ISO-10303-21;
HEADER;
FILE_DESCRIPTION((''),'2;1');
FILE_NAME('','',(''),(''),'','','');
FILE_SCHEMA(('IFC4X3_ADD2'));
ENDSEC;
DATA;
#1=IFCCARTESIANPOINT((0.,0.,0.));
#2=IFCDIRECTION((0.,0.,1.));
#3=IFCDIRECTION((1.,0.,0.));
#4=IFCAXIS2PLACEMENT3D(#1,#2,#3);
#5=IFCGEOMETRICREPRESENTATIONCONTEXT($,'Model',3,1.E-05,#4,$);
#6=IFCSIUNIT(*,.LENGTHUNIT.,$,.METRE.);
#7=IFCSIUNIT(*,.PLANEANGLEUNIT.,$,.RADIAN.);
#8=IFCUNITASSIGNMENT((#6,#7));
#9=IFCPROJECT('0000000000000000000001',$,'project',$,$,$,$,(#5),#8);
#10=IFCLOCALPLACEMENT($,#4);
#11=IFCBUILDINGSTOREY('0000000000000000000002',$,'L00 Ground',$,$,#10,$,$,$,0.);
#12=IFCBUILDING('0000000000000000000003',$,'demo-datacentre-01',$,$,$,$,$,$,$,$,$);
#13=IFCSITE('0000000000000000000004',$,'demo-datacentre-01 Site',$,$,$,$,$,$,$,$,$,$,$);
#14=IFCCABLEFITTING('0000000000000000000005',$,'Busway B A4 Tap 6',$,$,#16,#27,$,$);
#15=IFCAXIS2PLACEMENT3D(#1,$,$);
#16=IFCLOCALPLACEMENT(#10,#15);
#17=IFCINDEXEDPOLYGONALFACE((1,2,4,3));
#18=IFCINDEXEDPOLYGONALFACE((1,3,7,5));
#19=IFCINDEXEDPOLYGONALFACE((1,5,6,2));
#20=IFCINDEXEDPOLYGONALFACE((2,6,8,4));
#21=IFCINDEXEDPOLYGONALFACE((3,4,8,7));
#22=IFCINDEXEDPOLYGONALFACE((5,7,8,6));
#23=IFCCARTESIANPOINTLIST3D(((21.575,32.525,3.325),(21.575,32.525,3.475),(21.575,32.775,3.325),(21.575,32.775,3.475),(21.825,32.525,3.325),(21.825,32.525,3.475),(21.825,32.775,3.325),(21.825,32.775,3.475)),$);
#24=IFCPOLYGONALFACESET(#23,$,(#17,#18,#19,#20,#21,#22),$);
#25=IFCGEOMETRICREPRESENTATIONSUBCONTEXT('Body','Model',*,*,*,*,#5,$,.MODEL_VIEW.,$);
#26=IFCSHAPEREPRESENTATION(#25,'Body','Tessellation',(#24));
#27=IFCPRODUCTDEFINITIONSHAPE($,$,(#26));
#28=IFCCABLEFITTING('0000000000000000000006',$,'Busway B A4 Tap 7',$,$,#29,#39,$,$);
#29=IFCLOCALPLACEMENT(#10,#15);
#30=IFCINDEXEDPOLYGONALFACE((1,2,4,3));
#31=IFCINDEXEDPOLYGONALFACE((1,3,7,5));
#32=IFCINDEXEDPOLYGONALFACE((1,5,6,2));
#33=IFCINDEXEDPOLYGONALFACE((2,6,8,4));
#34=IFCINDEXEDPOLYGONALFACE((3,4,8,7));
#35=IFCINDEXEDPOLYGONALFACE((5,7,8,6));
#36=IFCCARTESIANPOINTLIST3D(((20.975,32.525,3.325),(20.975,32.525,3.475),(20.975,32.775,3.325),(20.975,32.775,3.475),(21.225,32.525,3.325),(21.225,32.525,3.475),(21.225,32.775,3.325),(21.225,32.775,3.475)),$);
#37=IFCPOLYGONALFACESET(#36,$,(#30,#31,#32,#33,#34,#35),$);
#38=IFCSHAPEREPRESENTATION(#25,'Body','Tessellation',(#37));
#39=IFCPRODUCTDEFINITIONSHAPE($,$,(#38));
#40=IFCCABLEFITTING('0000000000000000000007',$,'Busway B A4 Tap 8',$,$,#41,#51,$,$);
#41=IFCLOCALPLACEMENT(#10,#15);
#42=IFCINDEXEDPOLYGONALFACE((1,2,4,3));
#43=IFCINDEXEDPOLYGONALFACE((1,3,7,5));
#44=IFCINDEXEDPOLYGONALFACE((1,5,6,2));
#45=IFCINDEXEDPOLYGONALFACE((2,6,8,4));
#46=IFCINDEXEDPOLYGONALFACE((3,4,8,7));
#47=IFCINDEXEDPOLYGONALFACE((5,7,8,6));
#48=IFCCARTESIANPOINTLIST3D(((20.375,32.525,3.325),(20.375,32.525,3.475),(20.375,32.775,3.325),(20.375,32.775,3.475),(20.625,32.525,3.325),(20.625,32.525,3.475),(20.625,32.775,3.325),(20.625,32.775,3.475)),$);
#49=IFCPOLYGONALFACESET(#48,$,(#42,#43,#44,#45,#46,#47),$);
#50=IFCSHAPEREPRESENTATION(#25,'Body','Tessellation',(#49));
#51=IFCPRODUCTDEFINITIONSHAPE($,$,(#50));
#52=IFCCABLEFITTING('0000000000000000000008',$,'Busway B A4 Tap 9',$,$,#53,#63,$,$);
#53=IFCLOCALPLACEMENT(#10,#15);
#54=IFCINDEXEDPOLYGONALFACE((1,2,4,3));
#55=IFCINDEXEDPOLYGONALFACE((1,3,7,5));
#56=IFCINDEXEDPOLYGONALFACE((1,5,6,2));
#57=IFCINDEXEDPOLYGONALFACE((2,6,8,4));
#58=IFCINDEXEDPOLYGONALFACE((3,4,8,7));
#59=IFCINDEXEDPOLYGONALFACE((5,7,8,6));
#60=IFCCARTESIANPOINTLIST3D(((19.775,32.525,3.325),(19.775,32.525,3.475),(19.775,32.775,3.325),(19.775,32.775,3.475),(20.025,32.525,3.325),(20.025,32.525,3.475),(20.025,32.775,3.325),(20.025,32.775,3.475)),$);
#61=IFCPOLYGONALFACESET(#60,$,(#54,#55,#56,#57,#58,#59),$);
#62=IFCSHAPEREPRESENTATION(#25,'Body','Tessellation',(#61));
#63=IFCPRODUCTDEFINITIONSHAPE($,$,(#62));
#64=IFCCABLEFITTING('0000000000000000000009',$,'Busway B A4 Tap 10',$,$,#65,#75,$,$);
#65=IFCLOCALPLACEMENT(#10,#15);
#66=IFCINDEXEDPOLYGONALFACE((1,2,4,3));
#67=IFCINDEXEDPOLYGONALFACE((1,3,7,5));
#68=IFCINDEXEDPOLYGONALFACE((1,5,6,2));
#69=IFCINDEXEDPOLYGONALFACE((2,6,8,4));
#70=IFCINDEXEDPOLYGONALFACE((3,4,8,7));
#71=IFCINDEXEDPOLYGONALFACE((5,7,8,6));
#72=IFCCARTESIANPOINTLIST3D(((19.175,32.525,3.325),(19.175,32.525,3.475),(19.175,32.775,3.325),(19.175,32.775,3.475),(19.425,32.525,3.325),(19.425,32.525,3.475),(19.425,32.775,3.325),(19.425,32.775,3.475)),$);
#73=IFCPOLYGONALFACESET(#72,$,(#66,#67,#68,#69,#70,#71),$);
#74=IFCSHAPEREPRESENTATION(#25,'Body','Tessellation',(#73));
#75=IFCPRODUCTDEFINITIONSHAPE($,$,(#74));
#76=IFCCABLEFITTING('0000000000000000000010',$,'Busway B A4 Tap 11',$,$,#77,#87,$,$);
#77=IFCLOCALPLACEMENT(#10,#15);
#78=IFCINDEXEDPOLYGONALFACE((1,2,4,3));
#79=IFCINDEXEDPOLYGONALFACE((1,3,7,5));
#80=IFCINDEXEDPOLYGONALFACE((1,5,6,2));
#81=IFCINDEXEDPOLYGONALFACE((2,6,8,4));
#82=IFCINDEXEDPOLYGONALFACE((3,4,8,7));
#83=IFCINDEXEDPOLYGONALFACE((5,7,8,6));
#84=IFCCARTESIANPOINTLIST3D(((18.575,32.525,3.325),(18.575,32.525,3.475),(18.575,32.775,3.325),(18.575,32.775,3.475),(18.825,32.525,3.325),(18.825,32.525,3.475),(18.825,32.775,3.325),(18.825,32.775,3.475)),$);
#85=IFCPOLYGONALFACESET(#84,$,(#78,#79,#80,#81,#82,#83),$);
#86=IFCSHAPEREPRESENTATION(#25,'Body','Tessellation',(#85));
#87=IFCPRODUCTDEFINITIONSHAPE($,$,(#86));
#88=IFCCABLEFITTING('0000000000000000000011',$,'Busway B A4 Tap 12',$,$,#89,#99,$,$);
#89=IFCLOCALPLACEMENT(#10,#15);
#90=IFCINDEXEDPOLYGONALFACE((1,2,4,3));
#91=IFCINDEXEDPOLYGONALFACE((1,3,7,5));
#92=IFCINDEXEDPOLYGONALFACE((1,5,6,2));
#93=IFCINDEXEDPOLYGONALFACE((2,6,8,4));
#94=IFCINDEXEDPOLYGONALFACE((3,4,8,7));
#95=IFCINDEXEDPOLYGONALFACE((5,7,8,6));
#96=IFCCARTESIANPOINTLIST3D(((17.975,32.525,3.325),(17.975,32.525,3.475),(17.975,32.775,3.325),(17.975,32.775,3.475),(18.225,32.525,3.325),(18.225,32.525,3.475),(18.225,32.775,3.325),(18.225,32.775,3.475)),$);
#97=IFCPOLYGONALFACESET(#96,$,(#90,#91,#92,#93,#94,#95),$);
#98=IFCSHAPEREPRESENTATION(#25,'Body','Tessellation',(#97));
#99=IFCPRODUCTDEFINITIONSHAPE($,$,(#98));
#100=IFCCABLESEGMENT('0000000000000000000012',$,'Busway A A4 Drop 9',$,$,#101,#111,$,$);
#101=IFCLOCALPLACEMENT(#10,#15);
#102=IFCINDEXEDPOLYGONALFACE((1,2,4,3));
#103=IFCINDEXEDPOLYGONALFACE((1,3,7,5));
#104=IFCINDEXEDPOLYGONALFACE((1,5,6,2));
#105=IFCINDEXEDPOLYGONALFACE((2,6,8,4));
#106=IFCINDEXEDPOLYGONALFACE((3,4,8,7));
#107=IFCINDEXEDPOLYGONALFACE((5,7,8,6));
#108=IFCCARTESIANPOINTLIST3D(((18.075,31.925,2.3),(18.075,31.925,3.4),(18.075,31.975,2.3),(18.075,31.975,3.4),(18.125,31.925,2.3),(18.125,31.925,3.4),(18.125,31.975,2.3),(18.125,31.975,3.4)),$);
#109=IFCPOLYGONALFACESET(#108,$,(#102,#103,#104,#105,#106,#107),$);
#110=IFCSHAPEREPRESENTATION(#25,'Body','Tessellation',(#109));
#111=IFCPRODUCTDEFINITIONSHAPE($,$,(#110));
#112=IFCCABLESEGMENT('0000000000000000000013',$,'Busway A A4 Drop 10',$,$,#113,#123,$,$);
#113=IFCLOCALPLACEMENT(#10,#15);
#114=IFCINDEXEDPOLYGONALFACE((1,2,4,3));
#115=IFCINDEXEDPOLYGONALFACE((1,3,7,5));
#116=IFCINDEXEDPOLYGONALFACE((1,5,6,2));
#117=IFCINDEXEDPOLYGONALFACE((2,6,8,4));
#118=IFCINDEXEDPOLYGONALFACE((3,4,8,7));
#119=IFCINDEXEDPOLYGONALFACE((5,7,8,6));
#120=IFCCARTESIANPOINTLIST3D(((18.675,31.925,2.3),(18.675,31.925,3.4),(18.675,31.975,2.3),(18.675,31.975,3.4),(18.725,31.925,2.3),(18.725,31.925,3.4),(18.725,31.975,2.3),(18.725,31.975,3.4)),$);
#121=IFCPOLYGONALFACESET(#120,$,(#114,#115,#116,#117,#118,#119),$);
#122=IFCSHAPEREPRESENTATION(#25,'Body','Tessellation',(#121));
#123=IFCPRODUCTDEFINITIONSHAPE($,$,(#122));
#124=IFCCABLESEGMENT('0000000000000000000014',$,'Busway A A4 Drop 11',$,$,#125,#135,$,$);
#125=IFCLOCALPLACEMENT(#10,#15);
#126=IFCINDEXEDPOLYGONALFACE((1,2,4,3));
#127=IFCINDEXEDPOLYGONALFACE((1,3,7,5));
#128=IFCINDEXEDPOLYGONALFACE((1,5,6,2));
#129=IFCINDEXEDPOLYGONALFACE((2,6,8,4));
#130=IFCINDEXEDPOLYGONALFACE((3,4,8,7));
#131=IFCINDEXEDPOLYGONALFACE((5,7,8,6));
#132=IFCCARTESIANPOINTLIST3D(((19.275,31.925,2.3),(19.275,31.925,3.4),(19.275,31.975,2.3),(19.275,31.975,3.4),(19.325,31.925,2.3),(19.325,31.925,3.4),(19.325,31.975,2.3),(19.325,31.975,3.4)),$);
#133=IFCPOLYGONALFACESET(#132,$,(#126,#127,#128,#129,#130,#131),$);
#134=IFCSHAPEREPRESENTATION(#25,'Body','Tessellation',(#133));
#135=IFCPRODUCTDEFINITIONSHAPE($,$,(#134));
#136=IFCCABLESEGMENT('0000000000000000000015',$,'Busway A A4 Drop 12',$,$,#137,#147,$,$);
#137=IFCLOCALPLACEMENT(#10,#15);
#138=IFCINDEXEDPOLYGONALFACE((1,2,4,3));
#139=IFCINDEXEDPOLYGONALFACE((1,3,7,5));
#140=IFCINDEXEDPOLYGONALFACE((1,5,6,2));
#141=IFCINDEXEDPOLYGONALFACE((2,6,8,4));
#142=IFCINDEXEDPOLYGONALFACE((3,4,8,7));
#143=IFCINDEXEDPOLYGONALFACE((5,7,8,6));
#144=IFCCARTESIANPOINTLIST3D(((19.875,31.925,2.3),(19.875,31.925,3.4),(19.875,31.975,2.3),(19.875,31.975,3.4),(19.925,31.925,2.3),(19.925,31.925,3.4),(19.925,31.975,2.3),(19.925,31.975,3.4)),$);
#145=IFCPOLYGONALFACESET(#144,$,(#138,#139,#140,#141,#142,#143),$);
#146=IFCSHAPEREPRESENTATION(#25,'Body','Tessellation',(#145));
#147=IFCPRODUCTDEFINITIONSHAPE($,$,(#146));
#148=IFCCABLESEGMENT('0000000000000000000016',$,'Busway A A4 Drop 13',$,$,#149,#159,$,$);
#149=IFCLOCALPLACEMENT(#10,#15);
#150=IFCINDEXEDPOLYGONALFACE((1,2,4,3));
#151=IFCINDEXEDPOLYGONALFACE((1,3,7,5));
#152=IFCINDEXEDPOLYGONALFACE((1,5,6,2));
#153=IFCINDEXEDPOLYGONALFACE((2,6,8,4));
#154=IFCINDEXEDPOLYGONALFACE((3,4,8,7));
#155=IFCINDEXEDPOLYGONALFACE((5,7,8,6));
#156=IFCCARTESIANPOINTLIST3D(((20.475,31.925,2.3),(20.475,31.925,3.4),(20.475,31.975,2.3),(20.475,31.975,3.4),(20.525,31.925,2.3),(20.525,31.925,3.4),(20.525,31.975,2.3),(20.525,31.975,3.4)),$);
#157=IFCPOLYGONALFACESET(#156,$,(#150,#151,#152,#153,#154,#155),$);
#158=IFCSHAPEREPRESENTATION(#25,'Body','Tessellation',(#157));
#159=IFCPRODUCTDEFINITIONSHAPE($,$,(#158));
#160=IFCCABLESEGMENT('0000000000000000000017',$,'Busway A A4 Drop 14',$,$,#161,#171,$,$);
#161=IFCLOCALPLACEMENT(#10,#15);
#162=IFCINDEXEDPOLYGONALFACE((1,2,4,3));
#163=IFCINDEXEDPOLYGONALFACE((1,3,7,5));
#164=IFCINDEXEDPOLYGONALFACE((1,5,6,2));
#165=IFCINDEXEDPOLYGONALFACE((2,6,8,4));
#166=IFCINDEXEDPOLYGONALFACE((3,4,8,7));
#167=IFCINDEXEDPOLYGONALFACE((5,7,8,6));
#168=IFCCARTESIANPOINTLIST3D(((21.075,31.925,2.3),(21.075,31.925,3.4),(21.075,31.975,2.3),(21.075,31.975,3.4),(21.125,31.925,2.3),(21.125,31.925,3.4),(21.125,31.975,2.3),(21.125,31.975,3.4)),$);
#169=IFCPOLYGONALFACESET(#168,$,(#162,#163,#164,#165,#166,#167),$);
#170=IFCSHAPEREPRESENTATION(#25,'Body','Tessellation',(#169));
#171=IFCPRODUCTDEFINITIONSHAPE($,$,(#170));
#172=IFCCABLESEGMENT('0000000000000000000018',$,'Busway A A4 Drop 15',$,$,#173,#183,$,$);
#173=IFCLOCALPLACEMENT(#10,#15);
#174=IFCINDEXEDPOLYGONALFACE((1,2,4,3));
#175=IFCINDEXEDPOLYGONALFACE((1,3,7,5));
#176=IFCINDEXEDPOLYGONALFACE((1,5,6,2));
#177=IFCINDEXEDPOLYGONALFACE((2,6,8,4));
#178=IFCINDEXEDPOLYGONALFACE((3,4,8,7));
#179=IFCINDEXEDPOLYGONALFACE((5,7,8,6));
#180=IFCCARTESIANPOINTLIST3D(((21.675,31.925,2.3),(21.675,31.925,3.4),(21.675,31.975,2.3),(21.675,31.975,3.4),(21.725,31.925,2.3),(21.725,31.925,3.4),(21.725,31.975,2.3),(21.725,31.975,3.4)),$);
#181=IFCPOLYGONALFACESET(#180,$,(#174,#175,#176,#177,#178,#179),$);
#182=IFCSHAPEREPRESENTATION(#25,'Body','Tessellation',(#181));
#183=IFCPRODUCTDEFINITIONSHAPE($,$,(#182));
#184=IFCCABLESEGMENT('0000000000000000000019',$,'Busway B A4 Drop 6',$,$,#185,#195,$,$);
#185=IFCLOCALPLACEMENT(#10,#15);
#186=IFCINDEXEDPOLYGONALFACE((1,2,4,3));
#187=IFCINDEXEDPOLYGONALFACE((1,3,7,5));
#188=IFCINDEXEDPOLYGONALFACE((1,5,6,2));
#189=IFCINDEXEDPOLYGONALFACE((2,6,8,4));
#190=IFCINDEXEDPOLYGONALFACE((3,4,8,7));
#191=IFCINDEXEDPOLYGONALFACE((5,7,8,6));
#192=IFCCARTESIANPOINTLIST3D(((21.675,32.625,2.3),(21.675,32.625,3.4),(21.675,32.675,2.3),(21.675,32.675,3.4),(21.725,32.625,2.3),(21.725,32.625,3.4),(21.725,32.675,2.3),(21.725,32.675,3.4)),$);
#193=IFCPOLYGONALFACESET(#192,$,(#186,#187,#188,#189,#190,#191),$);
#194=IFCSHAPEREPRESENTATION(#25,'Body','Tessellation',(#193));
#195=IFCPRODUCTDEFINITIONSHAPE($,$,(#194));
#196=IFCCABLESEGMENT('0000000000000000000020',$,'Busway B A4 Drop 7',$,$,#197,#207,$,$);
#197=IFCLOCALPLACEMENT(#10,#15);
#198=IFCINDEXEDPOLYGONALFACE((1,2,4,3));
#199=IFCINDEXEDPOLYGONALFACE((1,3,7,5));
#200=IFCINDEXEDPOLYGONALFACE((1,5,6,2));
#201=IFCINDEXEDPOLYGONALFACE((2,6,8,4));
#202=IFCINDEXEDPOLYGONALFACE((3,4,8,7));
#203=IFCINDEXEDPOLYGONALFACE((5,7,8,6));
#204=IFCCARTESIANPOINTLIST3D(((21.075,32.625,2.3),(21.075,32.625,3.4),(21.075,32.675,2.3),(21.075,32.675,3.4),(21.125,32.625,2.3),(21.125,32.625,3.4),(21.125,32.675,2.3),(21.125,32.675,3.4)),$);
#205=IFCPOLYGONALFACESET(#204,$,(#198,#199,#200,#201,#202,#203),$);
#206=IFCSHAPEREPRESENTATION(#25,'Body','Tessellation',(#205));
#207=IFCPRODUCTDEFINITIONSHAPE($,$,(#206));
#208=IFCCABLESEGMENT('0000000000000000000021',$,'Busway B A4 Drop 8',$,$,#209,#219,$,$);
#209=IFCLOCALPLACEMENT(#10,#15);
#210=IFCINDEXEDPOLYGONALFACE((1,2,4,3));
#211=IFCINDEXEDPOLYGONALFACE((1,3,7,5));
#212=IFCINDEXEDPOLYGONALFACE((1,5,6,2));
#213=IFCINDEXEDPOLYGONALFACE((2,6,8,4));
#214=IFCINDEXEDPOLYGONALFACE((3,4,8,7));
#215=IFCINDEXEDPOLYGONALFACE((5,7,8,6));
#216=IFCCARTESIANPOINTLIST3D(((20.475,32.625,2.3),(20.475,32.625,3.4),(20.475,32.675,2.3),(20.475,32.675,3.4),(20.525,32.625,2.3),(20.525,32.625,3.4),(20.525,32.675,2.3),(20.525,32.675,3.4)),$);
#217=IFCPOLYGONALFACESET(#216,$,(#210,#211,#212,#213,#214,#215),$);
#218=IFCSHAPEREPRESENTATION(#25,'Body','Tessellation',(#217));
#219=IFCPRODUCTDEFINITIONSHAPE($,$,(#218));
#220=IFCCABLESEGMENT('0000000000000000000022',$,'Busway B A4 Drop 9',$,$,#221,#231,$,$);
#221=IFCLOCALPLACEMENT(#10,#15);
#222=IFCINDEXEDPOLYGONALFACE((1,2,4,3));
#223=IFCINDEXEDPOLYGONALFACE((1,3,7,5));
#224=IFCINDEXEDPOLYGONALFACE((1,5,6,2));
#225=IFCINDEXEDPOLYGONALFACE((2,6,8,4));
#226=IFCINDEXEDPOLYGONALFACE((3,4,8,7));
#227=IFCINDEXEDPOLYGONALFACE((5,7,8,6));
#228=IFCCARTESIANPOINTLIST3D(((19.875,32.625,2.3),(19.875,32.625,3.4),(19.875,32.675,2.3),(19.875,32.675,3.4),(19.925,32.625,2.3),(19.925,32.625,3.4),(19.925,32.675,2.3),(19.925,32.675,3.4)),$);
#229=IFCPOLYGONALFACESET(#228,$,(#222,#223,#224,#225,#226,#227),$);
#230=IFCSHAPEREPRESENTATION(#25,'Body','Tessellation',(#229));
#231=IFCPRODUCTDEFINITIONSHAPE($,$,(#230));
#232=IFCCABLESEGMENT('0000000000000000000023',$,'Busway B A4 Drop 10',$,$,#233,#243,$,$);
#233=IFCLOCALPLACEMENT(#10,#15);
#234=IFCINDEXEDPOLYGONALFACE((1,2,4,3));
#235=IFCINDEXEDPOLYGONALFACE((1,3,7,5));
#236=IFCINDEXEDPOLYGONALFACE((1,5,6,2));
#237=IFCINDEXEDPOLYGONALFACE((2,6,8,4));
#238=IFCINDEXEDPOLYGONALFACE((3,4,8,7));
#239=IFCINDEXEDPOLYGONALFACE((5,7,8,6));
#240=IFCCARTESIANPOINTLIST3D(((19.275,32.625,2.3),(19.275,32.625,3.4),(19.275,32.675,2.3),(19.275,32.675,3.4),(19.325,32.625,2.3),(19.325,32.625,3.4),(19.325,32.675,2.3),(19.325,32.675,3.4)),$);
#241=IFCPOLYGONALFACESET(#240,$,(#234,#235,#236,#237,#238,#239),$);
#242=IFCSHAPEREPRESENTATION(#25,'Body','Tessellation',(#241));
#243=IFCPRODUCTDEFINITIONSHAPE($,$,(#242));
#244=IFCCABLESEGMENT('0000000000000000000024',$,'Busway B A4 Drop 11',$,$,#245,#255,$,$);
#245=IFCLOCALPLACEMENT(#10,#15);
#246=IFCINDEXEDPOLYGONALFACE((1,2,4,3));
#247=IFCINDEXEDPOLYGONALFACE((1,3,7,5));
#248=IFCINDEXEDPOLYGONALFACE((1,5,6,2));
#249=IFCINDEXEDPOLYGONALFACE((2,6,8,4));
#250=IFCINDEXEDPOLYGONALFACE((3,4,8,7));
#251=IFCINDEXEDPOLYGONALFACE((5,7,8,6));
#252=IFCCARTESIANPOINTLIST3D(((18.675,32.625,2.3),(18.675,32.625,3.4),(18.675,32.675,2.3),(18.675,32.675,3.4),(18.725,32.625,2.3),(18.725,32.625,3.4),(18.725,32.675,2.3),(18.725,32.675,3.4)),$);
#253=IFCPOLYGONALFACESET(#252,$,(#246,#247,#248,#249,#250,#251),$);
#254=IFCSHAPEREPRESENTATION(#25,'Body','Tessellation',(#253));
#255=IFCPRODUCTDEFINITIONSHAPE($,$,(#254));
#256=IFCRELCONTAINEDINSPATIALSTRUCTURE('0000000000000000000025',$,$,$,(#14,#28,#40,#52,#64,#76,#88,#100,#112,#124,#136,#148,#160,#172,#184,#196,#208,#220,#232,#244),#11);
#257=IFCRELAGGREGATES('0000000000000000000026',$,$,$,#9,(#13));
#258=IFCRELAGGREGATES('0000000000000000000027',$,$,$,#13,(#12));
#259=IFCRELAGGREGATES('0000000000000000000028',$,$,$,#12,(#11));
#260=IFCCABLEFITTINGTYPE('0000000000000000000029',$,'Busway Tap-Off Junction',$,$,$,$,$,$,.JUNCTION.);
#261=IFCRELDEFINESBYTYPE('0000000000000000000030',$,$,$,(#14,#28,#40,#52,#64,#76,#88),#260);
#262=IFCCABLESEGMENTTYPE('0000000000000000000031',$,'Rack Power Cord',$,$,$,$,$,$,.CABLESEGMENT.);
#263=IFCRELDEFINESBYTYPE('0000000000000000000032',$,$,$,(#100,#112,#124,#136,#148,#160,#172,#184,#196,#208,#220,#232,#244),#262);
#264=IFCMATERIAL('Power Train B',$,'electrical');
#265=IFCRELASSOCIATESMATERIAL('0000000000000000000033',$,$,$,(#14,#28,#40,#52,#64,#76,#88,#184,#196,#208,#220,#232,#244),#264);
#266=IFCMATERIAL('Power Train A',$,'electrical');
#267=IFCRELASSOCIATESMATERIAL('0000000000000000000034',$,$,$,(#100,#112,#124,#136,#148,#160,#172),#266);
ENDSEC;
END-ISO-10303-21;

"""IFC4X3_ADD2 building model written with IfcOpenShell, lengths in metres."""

from ifc_helpers import new_model, si_unit, frame, origin_with_axes, place, context, subcontext, project, spatial, rectangle, extrude, material, type_object, element, save


model = new_model("IFC4X3_ADD2")

# Units and contexts
model_context = context("Model", 3, precision=1e-05, world=origin_with_axes())
body_context = subcontext(model_context, "Body", "Model", "MODEL_VIEW")
ifc_project = project(units=[si_unit("LENGTHUNIT", "METRE"), si_unit("PLANEANGLEUNIT", "RADIAN")], contexts=[model_context])

# Site, building, storey
site = spatial("IfcSite", under=ifc_project, Name="demo-datacentre-01 Site")
building = spatial("IfcBuilding", under=site, Name="demo-datacentre-01")
storey_placement = place(None, origin_with_axes())
storey = spatial("IfcBuildingStorey", under=building, at=storey_placement, Name="L00 Ground", Elevation=0.0)

# Shared definitions
ifc_material_1 = material(Name="Power Train A", Category="electrical")
ifc_material_2 = material(Name="Power Train B", Category="electrical")

# Cable fittings
cable_fitting_type = type_object("IfcCableFittingType", Name="Busway Tap-Off Junction", PredefinedType="JUNCTION")
for number, where, z_axis, x_axis, name in (
    (1, (21.7, 32.65, 3.325), (0.0, 0.0, 1.0), (1.0, 0.0, 0.0), "Busway B A4 Tap 6"),
    (2, (21.1, 32.65, 3.325), (0.0, 0.0, 1.0), (1.0, 0.0, 0.0), "Busway B A4 Tap 7"),
    (3, (20.5, 32.65, 3.325), (0.0, 0.0, 1.0), (1.0, 0.0, 0.0), "Busway B A4 Tap 8"),
    (4, (19.9, 32.65, 3.325), (0.0, 0.0, 1.0), (1.0, 0.0, 0.0), "Busway B A4 Tap 9"),
    (5, (19.3, 32.65, 3.325), (0.0, 0.0, 1.0), (1.0, 0.0, 0.0), "Busway B A4 Tap 10"),
    (6, (18.7, 32.65, 3.325), (0.0, 0.0, 1.0), (1.0, 0.0, 0.0), "Busway B A4 Tap 11"),
    (7, (18.1, 32.65, 3.325), (0.0, 0.0, 1.0), (1.0, 0.0, 0.0), "Busway B A4 Tap 12"),
):
    element("IfcCableFitting", number, at=place(storey_placement, frame(where, z_axis=z_axis, x_axis=x_axis)), inside=storey, type_object=cable_fitting_type, material=ifc_material_2, Name=name, context=body_context, shape_type="SweptSolid", body=[
        extrude(rectangle(XDim=0.25, YDim=0.25), origin_with_axes(), (0.0, 0.0, 1.0), 0.15),
    ])

# Cable segments
cable_segment_type_1 = type_object("IfcCableSegmentType", Name="Rack Power Cord", PredefinedType="CABLESEGMENT")
for number, where, z_axis, x_axis, name in (
    (8, (18.1, 31.95, 3.4), (0.0, 0.0, -1.0), (1.0, 0.0, 0.0), "Busway A A4 Drop 9"),
    (9, (18.7, 31.95, 3.4), (0.0, 0.0, -1.0), (1.0, 0.0, 0.0), "Busway A A4 Drop 10"),
    (10, (19.3, 31.95, 3.4), (0.0, 0.0, -1.0), (1.0, 0.0, 0.0), "Busway A A4 Drop 11"),
    (11, (19.9, 31.95, 3.4), (0.0, 0.0, -1.0), (1.0, 0.0, 0.0), "Busway A A4 Drop 12"),
    (12, (20.5, 31.95, 3.4), (0.0, 0.0, -1.0), (1.0, 0.0, 0.0), "Busway A A4 Drop 13"),
    (13, (21.1, 31.95, 3.4), (0.0, 0.0, -1.0), (1.0, 0.0, 0.0), "Busway A A4 Drop 14"),
    (14, (21.7, 31.95, 3.4), (0.0, 0.0, -1.0), (1.0, 0.0, 0.0), "Busway A A4 Drop 15"),
):
    element("IfcCableSegment", number, at=place(storey_placement, frame(where, z_axis=z_axis, x_axis=x_axis)), inside=storey, type_object=cable_segment_type_1, material=ifc_material_1, Name=name, context=body_context, shape_type="SweptSolid", body=[
        extrude(rectangle(XDim=0.05, YDim=0.05), origin_with_axes(), (0.0, 0.0, 1.0), 1.1),
    ])
for number, where, z_axis, x_axis, name in (
    (15, (21.7, 32.65, 3.4), (0.0, 0.0, -1.0), (1.0, 0.0, 0.0), "Busway B A4 Drop 6"),
    (16, (21.1, 32.65, 3.4), (0.0, 0.0, -1.0), (1.0, 0.0, 0.0), "Busway B A4 Drop 7"),
    (17, (20.5, 32.65, 3.4), (0.0, 0.0, -1.0), (1.0, 0.0, 0.0), "Busway B A4 Drop 8"),
    (18, (19.9, 32.65, 3.4), (0.0, 0.0, -1.0), (1.0, 0.0, 0.0), "Busway B A4 Drop 9"),
    (19, (19.3, 32.65, 3.4), (0.0, 0.0, -1.0), (1.0, 0.0, 0.0), "Busway B A4 Drop 10"),
    (20, (18.7, 32.65, 3.4), (0.0, 0.0, -1.0), (1.0, 0.0, 0.0), "Busway B A4 Drop 11"),
):
    element("IfcCableSegment", number, at=place(storey_placement, frame(where, z_axis=z_axis, x_axis=x_axis)), inside=storey, type_object=cable_segment_type_1, material=ifc_material_2, Name=name, context=body_context, shape_type="SweptSolid", body=[
        extrude(rectangle(XDim=0.05, YDim=0.05), origin_with_axes(), (0.0, 0.0, 1.0), 1.1),
    ])

save(model, "model.ifc")
